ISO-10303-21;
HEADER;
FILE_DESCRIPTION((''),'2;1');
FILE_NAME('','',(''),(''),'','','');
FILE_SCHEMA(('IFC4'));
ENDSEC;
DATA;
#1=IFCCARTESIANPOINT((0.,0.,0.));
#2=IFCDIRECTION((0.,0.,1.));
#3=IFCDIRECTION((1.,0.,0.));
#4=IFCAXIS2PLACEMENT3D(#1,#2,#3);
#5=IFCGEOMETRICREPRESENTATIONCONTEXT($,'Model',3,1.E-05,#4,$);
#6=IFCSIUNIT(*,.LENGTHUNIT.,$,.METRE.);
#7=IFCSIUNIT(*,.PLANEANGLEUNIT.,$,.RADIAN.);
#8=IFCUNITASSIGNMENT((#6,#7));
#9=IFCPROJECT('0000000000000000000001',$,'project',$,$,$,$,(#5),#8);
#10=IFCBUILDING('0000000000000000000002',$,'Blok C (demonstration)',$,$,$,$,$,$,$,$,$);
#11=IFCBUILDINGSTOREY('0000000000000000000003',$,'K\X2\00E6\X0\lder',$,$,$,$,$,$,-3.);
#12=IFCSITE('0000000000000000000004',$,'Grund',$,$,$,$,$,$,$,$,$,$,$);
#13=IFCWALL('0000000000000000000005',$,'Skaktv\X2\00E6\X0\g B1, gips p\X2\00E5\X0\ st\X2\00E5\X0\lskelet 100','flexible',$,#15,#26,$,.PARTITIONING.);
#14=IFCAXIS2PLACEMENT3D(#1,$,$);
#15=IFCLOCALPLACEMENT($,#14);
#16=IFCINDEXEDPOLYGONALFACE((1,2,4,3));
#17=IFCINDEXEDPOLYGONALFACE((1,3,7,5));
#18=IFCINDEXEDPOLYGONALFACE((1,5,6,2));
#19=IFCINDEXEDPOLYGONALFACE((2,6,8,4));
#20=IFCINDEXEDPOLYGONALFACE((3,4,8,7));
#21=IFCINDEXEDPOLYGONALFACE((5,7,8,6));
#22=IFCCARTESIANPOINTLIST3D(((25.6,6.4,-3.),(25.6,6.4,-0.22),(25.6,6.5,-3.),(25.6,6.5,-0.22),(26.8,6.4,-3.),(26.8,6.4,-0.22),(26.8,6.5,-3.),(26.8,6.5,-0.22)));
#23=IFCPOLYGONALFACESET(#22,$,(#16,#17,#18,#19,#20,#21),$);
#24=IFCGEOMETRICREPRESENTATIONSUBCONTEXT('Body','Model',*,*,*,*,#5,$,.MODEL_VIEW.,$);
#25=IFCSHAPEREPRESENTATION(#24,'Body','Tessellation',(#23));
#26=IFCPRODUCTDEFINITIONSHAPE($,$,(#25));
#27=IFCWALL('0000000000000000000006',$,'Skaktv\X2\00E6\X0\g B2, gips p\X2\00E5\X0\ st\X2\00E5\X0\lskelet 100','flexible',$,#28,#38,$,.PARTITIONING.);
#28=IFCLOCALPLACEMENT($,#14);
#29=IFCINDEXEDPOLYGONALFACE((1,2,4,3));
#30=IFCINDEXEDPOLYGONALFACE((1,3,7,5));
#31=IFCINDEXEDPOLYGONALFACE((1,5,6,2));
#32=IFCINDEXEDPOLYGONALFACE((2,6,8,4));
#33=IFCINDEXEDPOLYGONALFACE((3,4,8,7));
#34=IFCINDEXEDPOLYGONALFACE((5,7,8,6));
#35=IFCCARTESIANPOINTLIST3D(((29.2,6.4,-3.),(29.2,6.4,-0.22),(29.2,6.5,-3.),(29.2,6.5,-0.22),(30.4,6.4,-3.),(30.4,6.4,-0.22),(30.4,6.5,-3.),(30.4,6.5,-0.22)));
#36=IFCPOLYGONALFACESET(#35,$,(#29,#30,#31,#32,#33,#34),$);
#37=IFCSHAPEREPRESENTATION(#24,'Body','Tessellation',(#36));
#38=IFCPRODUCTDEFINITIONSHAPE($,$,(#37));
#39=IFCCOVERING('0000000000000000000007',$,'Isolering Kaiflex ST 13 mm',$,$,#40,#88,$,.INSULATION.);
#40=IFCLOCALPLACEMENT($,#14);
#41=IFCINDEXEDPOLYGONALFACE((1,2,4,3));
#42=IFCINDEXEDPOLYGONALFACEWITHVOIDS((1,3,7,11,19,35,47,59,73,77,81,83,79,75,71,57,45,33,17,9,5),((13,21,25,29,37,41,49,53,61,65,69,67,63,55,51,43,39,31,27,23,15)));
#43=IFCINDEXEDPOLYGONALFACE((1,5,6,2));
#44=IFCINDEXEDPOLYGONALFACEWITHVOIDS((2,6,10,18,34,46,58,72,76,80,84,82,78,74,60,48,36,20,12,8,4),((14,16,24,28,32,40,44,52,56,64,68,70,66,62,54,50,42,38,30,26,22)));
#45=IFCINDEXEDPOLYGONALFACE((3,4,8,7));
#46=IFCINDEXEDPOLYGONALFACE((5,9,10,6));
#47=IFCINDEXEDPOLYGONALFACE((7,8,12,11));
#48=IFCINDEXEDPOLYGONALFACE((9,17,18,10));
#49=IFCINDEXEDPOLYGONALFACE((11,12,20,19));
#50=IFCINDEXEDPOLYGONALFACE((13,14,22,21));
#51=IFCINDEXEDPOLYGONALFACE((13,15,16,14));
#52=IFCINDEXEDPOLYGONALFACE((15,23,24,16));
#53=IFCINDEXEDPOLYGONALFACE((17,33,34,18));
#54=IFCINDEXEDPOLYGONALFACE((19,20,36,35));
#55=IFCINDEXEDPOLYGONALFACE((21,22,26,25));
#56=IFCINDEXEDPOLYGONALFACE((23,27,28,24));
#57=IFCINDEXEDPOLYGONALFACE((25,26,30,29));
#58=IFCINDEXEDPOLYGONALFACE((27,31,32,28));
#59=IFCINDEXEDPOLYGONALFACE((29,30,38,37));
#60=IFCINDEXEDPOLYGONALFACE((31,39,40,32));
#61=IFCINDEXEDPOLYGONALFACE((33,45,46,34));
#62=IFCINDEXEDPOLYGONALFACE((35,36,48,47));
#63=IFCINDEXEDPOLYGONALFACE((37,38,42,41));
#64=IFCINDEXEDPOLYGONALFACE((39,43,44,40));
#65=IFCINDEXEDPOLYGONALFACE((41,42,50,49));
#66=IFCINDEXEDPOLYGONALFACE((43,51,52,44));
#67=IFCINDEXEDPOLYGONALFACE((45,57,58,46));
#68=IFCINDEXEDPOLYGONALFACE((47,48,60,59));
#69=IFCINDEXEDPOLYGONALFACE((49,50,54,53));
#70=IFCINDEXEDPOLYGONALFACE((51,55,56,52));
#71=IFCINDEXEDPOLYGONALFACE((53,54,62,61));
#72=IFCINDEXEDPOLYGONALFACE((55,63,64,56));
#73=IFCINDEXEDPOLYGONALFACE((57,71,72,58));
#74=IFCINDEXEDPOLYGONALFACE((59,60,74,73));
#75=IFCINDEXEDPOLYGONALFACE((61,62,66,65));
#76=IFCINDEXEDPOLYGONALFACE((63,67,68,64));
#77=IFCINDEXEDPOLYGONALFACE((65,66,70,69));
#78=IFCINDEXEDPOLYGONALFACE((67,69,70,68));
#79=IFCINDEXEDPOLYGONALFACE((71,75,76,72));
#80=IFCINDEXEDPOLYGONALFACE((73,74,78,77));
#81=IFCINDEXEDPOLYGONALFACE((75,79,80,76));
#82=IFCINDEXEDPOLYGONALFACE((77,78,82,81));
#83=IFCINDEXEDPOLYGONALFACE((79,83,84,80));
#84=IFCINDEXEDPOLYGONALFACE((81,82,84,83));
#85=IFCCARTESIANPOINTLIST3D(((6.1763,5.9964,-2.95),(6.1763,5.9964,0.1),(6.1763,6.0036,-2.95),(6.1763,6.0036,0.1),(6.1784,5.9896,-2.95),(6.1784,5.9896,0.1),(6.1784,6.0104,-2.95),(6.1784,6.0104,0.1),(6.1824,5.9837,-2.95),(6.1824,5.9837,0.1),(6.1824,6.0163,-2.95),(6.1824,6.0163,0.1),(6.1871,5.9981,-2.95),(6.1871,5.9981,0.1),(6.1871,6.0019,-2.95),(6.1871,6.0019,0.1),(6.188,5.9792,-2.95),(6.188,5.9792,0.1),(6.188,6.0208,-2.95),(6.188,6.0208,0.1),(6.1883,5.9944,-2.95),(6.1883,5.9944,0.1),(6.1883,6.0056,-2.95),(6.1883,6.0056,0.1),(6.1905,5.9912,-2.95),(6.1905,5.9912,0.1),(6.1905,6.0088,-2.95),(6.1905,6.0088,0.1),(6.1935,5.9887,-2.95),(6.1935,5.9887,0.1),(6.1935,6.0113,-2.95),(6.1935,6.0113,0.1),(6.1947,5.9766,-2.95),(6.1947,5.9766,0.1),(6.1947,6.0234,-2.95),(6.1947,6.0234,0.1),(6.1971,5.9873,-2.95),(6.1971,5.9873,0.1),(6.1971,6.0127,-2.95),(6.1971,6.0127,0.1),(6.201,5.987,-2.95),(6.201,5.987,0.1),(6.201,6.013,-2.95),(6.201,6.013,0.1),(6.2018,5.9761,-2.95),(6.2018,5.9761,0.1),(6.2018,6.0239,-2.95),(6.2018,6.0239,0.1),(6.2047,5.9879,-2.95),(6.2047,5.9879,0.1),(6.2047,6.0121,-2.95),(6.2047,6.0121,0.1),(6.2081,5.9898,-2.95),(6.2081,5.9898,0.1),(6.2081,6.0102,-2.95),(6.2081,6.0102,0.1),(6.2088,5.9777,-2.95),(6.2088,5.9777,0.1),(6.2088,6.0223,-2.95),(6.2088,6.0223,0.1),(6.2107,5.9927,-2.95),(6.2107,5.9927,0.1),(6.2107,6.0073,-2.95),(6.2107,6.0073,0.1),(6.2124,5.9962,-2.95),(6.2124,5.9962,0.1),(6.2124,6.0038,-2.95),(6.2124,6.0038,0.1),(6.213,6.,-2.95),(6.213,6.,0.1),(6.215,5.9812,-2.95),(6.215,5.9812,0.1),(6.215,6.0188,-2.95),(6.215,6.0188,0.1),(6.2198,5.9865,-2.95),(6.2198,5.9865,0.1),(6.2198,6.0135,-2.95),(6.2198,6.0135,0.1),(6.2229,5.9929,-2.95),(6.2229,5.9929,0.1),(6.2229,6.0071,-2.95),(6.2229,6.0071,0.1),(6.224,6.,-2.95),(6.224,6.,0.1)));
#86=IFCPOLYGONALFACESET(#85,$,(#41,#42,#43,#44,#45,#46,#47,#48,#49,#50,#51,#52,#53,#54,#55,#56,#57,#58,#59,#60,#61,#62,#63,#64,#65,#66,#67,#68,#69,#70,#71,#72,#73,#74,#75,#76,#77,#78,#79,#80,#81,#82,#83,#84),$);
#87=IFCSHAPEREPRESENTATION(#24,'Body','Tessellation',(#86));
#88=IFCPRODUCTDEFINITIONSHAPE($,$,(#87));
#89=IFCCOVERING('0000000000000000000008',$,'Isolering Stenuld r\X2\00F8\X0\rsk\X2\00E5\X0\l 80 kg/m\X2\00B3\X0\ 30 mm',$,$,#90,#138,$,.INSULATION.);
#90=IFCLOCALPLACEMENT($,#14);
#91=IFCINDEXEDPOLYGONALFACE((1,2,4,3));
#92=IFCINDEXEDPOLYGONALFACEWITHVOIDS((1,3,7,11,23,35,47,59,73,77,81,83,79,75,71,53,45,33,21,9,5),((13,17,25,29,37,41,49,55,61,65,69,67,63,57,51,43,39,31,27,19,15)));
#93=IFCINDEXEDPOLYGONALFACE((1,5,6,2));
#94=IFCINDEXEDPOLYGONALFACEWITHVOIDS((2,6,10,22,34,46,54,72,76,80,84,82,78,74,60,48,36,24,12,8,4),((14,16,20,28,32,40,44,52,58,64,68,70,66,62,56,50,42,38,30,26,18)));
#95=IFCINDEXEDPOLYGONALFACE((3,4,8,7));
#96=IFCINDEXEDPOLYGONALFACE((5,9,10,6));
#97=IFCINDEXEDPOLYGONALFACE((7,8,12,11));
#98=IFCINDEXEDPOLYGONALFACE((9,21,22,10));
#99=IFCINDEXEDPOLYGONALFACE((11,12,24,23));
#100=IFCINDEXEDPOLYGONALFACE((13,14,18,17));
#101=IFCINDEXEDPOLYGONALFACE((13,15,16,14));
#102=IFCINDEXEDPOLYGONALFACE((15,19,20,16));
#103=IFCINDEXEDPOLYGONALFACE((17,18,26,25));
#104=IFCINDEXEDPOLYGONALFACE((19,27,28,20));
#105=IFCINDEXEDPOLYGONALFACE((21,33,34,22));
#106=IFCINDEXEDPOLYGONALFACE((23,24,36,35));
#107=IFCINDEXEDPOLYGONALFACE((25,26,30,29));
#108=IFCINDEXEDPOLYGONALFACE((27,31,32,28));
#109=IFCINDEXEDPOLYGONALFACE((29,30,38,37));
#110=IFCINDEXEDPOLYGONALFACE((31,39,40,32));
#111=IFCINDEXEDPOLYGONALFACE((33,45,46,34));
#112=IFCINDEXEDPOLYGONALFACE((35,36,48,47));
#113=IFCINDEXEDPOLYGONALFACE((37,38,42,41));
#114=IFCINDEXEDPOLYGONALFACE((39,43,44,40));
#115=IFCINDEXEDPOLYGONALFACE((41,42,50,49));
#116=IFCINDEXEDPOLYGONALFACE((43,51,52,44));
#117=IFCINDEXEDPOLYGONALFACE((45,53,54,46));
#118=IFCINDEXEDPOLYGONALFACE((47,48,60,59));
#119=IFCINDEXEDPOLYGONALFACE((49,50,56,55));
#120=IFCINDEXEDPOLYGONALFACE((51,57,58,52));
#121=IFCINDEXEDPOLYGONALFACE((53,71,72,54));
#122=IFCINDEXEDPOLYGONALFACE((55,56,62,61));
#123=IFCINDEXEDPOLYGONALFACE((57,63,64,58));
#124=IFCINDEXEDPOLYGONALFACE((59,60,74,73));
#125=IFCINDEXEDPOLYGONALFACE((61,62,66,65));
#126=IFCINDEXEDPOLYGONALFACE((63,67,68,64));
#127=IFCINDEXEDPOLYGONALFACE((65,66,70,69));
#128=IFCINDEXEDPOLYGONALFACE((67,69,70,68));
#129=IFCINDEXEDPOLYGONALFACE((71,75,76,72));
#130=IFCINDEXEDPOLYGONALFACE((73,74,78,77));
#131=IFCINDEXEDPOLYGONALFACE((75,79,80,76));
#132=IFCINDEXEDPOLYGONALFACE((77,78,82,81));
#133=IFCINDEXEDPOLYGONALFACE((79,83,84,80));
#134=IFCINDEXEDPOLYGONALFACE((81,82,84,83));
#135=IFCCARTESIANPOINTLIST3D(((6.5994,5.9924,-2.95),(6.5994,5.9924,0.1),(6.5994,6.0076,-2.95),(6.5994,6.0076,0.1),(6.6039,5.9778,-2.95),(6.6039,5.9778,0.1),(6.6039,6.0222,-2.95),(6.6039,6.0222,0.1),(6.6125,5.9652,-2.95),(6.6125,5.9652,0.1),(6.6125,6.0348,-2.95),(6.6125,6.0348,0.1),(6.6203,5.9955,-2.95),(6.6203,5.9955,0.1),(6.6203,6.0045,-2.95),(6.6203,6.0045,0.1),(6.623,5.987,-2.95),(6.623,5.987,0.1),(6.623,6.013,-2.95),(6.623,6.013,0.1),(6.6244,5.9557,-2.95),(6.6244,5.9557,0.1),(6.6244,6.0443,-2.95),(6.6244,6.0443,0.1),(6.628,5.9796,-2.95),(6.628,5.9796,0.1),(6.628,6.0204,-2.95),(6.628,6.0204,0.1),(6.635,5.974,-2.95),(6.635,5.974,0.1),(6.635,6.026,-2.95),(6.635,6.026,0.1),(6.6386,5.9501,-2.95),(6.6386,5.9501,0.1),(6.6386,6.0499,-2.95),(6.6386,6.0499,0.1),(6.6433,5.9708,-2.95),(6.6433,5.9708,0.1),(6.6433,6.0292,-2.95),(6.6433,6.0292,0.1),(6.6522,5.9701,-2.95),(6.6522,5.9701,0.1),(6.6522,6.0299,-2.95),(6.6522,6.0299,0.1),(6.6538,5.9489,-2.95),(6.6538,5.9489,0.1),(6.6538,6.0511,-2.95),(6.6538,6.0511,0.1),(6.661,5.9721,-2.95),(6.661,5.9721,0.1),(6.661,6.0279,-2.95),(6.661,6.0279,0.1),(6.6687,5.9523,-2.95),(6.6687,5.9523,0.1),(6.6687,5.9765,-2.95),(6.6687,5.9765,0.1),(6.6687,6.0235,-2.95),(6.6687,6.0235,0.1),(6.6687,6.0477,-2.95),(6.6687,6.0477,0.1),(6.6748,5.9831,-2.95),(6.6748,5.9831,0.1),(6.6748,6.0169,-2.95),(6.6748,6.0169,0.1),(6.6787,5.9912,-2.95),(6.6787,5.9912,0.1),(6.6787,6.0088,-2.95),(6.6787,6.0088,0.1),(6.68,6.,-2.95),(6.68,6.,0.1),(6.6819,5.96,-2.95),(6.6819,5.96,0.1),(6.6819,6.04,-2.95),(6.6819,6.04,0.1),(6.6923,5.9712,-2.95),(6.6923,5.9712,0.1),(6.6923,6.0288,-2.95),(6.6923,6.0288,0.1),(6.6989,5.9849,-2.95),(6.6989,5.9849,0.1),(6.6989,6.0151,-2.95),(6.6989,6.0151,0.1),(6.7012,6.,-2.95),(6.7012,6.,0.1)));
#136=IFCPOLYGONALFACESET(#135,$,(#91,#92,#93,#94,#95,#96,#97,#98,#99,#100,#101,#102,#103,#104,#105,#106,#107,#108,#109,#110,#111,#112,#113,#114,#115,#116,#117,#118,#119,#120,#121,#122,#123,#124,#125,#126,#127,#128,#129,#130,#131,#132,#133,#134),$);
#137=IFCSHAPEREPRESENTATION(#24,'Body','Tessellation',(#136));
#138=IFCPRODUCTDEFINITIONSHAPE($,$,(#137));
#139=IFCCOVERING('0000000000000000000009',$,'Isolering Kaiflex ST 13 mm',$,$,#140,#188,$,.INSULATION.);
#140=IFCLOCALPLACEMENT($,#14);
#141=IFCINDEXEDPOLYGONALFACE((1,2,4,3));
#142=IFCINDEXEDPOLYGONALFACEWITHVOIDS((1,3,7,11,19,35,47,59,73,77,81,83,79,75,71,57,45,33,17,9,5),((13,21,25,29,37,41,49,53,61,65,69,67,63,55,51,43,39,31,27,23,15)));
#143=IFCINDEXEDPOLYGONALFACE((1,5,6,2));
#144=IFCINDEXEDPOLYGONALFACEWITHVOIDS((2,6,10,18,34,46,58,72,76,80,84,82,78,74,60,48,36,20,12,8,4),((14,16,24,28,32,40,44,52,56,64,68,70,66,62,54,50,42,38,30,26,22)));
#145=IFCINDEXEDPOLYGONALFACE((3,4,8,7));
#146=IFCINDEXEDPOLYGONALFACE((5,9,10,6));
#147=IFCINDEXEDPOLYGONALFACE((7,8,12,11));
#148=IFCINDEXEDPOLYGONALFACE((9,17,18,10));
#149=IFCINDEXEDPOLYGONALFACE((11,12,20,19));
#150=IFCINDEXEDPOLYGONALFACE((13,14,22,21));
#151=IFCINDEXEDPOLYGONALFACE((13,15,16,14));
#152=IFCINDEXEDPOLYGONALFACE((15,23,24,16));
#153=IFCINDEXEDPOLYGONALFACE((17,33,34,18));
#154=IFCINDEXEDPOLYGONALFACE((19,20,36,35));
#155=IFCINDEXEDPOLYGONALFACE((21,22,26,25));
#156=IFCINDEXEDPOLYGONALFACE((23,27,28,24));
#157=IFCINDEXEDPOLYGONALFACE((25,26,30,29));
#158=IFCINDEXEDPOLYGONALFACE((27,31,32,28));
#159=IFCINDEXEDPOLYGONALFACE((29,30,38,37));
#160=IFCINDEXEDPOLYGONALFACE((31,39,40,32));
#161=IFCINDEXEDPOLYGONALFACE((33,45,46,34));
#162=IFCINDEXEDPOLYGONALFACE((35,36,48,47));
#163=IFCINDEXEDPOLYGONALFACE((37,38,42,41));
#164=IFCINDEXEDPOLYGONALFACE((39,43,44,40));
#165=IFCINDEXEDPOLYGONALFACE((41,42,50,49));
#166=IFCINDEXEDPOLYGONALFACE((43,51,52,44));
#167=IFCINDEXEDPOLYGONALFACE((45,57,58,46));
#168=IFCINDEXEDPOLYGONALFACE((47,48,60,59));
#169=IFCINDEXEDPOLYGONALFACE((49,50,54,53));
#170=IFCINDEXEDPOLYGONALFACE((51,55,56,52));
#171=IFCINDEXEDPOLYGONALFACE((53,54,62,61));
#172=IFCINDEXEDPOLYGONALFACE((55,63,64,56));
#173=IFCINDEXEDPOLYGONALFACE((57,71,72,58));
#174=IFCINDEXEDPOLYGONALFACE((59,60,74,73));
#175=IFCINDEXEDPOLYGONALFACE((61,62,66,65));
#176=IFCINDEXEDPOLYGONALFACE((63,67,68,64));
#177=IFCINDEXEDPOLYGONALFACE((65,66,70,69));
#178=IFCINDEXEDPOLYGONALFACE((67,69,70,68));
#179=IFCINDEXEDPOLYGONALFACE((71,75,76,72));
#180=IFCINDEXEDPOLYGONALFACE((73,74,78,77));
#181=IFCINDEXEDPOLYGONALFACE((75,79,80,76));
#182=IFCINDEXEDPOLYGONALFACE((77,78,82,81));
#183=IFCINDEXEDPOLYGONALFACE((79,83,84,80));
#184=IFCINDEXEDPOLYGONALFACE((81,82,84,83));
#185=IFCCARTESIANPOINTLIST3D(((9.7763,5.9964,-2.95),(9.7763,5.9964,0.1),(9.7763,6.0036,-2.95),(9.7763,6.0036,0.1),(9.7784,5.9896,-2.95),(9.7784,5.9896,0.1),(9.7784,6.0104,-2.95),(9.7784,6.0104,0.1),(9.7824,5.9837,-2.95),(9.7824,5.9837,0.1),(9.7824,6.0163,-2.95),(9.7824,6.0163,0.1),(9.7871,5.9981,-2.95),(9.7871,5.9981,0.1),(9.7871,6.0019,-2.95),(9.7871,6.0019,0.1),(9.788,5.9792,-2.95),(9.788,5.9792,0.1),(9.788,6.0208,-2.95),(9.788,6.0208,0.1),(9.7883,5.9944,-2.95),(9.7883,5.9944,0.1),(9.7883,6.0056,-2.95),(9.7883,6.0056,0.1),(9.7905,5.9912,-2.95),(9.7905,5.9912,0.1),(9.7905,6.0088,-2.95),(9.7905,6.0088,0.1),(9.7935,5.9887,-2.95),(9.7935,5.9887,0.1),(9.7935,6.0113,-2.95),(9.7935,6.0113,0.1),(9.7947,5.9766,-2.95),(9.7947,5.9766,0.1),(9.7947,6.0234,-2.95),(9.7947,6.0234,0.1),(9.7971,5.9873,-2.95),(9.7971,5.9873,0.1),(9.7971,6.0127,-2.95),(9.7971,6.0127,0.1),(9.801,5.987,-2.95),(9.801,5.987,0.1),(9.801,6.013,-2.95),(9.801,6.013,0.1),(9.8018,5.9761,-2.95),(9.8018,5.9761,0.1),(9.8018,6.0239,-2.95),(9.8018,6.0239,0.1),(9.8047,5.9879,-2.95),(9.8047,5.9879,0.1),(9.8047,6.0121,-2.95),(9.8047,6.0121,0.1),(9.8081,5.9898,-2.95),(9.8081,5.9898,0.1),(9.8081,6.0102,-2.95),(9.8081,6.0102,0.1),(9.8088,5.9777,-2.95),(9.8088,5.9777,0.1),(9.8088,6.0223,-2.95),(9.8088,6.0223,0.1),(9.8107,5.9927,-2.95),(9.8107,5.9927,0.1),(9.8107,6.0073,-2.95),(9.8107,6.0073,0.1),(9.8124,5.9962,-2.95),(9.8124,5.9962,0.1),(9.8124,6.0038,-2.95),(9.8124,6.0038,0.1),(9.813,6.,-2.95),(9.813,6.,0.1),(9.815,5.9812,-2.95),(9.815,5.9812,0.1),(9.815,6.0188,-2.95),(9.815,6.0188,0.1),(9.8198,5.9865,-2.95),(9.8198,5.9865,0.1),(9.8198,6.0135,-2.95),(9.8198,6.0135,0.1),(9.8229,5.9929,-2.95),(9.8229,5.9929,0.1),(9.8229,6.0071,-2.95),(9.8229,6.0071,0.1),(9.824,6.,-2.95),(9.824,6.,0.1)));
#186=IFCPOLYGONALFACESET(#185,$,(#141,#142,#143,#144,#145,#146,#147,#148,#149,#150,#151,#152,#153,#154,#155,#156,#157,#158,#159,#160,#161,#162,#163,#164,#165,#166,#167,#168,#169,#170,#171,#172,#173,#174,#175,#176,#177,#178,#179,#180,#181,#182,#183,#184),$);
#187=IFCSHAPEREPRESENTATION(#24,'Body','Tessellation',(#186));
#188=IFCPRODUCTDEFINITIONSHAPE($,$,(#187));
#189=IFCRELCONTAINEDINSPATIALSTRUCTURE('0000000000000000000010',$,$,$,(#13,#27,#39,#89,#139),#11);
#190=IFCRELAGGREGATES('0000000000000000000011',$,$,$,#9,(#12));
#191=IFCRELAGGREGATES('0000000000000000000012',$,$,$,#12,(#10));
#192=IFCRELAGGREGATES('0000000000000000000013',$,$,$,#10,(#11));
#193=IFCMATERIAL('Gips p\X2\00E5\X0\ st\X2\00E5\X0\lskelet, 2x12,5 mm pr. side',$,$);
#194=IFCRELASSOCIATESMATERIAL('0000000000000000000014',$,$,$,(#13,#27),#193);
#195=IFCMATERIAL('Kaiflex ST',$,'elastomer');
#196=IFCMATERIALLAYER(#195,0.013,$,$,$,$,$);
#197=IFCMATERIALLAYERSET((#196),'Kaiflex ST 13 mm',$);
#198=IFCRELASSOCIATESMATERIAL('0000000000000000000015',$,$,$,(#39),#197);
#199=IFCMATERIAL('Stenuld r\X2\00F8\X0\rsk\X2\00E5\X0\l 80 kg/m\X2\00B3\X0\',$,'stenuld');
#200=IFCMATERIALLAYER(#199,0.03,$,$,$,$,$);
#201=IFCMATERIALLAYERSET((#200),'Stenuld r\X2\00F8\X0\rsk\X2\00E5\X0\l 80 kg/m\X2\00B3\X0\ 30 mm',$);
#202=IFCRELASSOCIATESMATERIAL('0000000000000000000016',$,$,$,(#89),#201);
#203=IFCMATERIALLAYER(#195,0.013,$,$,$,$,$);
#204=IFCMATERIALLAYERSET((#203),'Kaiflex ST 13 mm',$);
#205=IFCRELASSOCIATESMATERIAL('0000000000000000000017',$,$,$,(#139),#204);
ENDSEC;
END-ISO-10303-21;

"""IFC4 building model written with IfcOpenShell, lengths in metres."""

from ifc_helpers import new_model, si_unit, frame, origin_with_axes, place, context, subcontext, project, spatial, polyline, hollow_circle, outline, extrude, material, layer, layer_set, element, save


model = new_model("IFC4")

# Units and contexts
model_context = context("Model", 3, precision=1e-05, world=origin_with_axes())
body_context = subcontext(model_context, "Body", "Model", "MODEL_VIEW")
ifc_project = project(units=[si_unit("LENGTHUNIT", "METRE"), si_unit("PLANEANGLEUNIT", "RADIAN")], contexts=[model_context])

# Site, building, storey
site = spatial("IfcSite", under=ifc_project, Name="Grund")
building = spatial("IfcBuilding", under=site, Name="Blok C (demonstration)")
storey = spatial("IfcBuildingStorey", under=building, Name="Kælder", Elevation=-3.0)

# Shared definitions
ifc_material_1 = material(Name="Gips på stålskelet, 2x12,5 mm pr. side")

# Walls
wall_1_placement = place(None, origin_with_axes())
element("IfcWall", 1, at=wall_1_placement, inside=storey, material=ifc_material_1, Name="Skaktvæg B1, gips på stålskelet 100", Description="flexible", PredefinedType="PARTITIONING", context=body_context, shape_type="SweptSolid", body=[
    extrude(outline(polyline([(25.6, 6.4), (26.8, 6.4), (26.8, 6.5), (25.6, 6.5), (25.6, 6.4)])), frame((0.0, 0.0, -3.0)), (0.0, 0.0, 1.0), 2.78),
])
wall_2_placement = place(None, origin_with_axes())
element("IfcWall", 2, at=wall_2_placement, inside=storey, material=ifc_material_1, Name="Skaktvæg B2, gips på stålskelet 100", Description="flexible", PredefinedType="PARTITIONING", context=body_context, shape_type="SweptSolid", body=[
    extrude(outline(polyline([(29.2, 6.4), (30.4, 6.4), (30.4, 6.5), (29.2, 6.5), (29.2, 6.4)])), frame((0.0, 0.0, -3.0)), (0.0, 0.0, 1.0), 2.78),
])

# Coverings
ifc_material_2 = material(Name="Kaiflex ST", Category="elastomer")
ifc_layer_1 = layer(ifc_material_2, 0.013)
ifc_layer_set_1 = layer_set([ifc_layer_1], Name="Kaiflex ST 13 mm")
covering_1_placement = place(None, origin_with_axes())
element("IfcCovering", 3, at=covering_1_placement, inside=storey, material=ifc_layer_set_1, Name="Isolering Kaiflex ST 13 mm", PredefinedType="INSULATION", context=body_context, shape_type="SweptSolid", body=[
    extrude(hollow_circle(Radius=0.024, WallThickness=0.011), frame((6.2, 6.0, -2.95), z_axis=(0.0, 0.0, 1.0), x_axis=(1.0, 0.0, 0.0)), (0.0, 0.0, 1.0), 3.05),
])
ifc_material_3 = material(Name="Stenuld rørskål 80 kg/m³", Category="stenuld")
ifc_layer_2 = layer(ifc_material_3, 0.03)
ifc_layer_set_2 = layer_set([ifc_layer_2], Name="Stenuld rørskål 80 kg/m³ 30 mm")
covering_2_placement = place(None, origin_with_axes())
element("IfcCovering", 4, at=covering_2_placement, inside=storey, material=ifc_layer_set_2, Name="Isolering Stenuld rørskål 80 kg/m³ 30 mm", PredefinedType="INSULATION", context=body_context, shape_type="SweptSolid", body=[
    extrude(hollow_circle(Radius=0.0512, WallThickness=0.0212), frame((6.65, 6.0, -2.95), z_axis=(0.0, 0.0, 1.0), x_axis=(1.0, 0.0, 0.0)), (0.0, 0.0, 1.0), 3.05),
])
ifc_layer_3 = layer(ifc_material_2, 0.013)
ifc_layer_set_3 = layer_set([ifc_layer_3], Name="Kaiflex ST 13 mm")
covering_3_placement = place(None, origin_with_axes())
element("IfcCovering", 5, at=covering_3_placement, inside=storey, material=ifc_layer_set_3, Name="Isolering Kaiflex ST 13 mm", PredefinedType="INSULATION", context=body_context, shape_type="SweptSolid", body=[
    extrude(hollow_circle(Radius=0.024, WallThickness=0.011), frame((9.8, 6.0, -2.95), z_axis=(0.0, 0.0, 1.0), x_axis=(1.0, 0.0, 0.0)), (0.0, 0.0, 1.0), 3.05),
])

save(model, "model.ifc")
